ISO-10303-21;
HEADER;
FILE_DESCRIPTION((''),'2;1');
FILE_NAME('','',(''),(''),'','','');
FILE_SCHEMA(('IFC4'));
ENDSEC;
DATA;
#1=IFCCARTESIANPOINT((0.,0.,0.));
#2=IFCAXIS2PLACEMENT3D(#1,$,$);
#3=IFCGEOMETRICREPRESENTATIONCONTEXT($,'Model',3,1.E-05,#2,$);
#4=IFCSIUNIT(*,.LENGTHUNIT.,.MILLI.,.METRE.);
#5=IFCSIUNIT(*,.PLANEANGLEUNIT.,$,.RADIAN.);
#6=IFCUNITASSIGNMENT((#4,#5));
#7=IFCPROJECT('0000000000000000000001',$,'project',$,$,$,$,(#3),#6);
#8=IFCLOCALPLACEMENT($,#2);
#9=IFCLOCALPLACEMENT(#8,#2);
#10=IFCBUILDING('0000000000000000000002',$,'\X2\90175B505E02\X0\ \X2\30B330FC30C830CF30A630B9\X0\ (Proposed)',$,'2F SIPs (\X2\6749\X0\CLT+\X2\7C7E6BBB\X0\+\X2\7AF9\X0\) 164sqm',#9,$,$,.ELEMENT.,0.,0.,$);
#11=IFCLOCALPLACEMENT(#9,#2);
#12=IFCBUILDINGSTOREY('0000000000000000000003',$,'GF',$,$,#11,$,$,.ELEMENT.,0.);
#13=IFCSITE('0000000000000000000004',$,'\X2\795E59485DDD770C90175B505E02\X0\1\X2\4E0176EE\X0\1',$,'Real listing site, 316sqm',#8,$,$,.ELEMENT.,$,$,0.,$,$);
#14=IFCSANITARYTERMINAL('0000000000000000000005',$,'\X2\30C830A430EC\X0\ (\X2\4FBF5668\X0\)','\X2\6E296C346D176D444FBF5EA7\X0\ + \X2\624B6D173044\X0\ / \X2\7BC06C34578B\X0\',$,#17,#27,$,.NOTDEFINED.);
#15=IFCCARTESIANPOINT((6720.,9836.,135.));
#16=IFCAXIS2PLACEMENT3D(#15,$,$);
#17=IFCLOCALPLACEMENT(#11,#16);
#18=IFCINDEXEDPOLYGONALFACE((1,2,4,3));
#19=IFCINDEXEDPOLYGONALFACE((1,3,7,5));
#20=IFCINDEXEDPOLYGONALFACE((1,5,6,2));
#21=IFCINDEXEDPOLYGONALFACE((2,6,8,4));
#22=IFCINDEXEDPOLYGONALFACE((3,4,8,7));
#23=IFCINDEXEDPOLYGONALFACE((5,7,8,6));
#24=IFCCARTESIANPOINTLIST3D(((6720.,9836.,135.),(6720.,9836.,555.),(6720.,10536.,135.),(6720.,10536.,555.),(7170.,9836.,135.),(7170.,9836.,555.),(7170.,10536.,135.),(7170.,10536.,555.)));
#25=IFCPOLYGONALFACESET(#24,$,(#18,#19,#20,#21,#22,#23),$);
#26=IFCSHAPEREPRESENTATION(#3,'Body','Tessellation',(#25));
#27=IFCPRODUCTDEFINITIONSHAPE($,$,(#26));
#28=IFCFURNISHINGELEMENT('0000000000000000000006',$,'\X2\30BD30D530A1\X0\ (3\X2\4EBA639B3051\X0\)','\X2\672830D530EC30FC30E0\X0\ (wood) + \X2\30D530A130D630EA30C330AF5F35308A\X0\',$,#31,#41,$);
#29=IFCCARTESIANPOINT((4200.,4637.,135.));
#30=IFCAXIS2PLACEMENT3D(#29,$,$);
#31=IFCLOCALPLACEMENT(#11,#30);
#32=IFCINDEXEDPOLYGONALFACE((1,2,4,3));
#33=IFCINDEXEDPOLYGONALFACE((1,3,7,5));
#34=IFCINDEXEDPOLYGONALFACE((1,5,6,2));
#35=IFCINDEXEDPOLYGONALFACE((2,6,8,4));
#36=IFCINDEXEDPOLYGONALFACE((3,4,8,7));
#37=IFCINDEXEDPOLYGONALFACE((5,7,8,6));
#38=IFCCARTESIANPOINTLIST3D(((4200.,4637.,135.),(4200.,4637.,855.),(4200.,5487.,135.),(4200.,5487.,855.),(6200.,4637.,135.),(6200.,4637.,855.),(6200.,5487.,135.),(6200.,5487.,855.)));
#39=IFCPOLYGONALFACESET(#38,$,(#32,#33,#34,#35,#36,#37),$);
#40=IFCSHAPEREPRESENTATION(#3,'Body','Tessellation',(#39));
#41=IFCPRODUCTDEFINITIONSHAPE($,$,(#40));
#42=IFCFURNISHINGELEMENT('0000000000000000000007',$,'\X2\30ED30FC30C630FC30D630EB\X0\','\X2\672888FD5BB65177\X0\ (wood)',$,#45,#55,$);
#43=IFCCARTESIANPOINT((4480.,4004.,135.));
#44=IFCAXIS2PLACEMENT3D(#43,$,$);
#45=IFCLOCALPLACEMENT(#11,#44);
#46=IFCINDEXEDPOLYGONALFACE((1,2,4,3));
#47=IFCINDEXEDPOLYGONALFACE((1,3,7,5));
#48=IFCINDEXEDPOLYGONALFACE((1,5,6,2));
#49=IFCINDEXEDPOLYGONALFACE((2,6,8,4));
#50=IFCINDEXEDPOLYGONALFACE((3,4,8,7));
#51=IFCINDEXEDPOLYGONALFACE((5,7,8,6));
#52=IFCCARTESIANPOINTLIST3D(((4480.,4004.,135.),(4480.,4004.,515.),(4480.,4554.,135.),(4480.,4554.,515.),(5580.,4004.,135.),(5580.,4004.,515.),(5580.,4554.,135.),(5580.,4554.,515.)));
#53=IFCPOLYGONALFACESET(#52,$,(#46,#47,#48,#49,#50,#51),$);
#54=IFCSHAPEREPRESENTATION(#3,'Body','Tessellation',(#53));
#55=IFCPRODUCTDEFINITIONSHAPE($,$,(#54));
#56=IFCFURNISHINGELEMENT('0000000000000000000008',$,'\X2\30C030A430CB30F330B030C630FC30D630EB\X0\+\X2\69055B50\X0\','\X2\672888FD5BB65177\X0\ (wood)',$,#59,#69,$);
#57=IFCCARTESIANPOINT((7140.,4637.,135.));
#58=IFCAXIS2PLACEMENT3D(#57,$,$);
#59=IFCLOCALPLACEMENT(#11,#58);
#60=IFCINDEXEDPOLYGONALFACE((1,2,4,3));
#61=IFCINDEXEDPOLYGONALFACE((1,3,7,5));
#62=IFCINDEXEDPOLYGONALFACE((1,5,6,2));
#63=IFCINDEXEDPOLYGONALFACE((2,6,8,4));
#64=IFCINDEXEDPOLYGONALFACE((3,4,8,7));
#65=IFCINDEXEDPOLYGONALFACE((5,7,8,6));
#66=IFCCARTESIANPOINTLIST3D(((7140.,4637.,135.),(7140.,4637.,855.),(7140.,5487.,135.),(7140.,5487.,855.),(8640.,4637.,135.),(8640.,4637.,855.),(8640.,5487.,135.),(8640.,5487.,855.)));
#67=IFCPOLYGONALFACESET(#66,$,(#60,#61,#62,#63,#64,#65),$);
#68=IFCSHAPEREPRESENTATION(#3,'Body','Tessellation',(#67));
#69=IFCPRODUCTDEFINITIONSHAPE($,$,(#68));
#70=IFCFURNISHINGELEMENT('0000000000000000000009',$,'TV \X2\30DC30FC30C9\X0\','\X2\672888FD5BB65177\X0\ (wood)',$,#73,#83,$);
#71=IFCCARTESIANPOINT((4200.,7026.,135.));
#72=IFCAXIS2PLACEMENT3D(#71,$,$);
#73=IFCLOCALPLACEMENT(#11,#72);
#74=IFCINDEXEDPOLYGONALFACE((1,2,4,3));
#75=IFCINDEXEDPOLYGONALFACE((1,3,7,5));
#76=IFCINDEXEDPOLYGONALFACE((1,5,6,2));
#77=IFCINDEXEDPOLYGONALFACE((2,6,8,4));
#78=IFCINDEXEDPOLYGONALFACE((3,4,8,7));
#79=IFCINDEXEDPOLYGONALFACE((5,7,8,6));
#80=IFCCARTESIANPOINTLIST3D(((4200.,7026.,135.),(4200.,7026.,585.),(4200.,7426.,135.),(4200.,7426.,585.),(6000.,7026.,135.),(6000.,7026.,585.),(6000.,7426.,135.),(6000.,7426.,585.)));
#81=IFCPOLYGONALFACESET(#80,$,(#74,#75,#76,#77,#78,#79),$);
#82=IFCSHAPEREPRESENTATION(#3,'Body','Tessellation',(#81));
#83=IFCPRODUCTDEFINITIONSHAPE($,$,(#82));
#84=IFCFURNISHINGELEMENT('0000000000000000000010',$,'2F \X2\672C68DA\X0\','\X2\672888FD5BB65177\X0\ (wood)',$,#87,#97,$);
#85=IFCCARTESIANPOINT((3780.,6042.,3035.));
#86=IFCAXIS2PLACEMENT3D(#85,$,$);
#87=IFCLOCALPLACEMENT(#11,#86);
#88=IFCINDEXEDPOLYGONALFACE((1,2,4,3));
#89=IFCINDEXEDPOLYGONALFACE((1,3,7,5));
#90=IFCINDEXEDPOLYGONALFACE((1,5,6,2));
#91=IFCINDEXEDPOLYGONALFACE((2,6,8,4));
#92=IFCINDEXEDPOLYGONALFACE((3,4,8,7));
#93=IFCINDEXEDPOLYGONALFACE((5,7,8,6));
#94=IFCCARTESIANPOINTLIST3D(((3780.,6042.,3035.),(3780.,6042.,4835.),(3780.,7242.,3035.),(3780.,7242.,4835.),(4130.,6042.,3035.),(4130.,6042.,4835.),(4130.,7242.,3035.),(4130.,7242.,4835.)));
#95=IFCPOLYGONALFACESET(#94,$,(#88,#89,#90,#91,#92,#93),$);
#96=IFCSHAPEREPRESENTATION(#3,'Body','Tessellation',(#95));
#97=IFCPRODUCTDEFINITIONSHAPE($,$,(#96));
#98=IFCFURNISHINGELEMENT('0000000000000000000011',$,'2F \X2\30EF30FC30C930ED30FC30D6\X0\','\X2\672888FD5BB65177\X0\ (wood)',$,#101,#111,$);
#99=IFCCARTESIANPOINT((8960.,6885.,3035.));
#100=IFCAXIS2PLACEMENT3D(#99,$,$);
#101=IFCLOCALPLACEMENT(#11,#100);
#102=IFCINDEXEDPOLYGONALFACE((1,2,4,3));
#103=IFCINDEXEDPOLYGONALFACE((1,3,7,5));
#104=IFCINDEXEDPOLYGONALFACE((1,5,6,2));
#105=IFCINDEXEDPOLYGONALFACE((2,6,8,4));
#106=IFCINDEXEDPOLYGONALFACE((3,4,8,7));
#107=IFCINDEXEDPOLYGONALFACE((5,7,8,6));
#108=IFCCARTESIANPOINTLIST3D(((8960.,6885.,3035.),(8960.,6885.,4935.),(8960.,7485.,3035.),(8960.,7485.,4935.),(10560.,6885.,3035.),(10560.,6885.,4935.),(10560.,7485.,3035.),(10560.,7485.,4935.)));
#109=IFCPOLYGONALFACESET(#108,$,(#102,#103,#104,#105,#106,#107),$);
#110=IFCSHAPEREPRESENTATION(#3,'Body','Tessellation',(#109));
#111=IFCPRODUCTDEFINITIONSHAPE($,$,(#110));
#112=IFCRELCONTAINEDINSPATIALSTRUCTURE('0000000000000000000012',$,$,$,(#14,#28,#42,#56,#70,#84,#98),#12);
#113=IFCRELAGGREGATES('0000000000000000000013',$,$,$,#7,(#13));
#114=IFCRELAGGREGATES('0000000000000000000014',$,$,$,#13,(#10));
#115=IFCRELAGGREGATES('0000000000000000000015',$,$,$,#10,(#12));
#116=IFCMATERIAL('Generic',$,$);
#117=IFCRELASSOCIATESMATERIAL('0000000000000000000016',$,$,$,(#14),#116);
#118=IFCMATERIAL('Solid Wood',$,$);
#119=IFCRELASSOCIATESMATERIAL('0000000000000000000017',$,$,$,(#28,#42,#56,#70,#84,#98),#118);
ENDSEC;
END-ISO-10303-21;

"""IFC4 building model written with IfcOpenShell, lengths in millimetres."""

from ifc_helpers import new_model, si_unit, frame, frame_2d, origin, place, context, project, spatial, rectangle, extrude, material, element, save


model = new_model("IFC4")

# Units and contexts
model_context = context("Model", 3, precision=1e-05, world=origin())
ifc_project = project(units=[si_unit("LENGTHUNIT", "METRE", prefix="MILLI"), si_unit("PLANEANGLEUNIT", "RADIAN")], contexts=[model_context])

# Site, building, storey
site_placement = place(None, origin())
site = spatial("IfcSite", under=ifc_project, at=site_placement, Name="神奈川県逗子市1丁目1", ObjectType="Real listing site, 316sqm", CompositionType="ELEMENT", RefElevation=0.0)
building_placement = place(site_placement, origin())
building = spatial("IfcBuilding", under=site, at=building_placement, Name="逗子市 コートハウス (Proposed)", ObjectType="2F SIPs (杉CLT+籾殻+竹) 164sqm", CompositionType="ELEMENT", ElevationOfRefHeight=0.0, ElevationOfTerrain=0.0)
storey_placement = place(building_placement, origin())
storey = spatial("IfcBuildingStorey", under=building, at=storey_placement, Name="GF", CompositionType="ELEMENT", Elevation=0.0)

# Shared definitions
ifc_material_1 = material(Name="Generic")

# Shared definitions
ifc_material_2 = material(Name="Solid Wood")

# Sanitary terminal
sanitary_terminal_1_placement = place(storey_placement, frame((6720.0, 9836.0, 135.0)))
element("IfcSanitaryTerminal", 1, at=sanitary_terminal_1_placement, inside=storey, material=ifc_material_1, Name="トイレ (便器)", Description="温水洗浄便座 + 手洗い / 節水型", PredefinedType="NOTDEFINED", context=model_context, shape_type="SweptSolid", body=[
    extrude(rectangle(XDim=450.0, YDim=700.0, at=frame_2d((225.0, 350.0))), frame((6720.0, 9836.0, 135.0)), (0.0, 0.0, 1.0), 420.0),
])

# Furnishing elements
furnishing_1_placement = place(storey_placement, frame((4200.0, 4637.0, 135.0)))
element("IfcFurnishingElement", 2, at=furnishing_1_placement, inside=storey, material=ifc_material_2, Name="ソファ (3人掛け)", Description="木フレーム (wood) + ファブリック張り", context=model_context, shape_type="SweptSolid", body=[
    extrude(rectangle(XDim=2000.0, YDim=850.0, at=frame_2d((1000.0, 425.0))), frame((4200.0, 4637.0, 135.0)), (0.0, 0.0, 1.0), 720.0),
])
furnishing_2_placement = place(storey_placement, frame((4480.0, 4004.0, 135.0)))
element("IfcFurnishingElement", 3, at=furnishing_2_placement, inside=storey, material=ifc_material_2, Name="ローテーブル", Description="木製家具 (wood)", context=model_context, shape_type="SweptSolid", body=[
    extrude(rectangle(XDim=1100.0, YDim=550.0, at=frame_2d((550.0, 275.0))), frame((4480.0, 4004.0, 135.0)), (0.0, 0.0, 1.0), 380.0),
])
furnishing_3_placement = place(storey_placement, frame((7140.0, 4637.0, 135.0)))
element("IfcFurnishingElement", 4, at=furnishing_3_placement, inside=storey, material=ifc_material_2, Name="ダイニングテーブル+椅子", Description="木製家具 (wood)", context=model_context, shape_type="SweptSolid", body=[
    extrude(rectangle(XDim=1500.0, YDim=850.0, at=frame_2d((750.0, 425.0))), frame((7140.0, 4637.0, 135.0)), (0.0, 0.0, 1.0), 720.0),
])
furnishing_4_placement = place(storey_placement, frame((4200.0, 7026.0, 135.0)))
element("IfcFurnishingElement", 5, at=furnishing_4_placement, inside=storey, material=ifc_material_2, Name="TV ボード", Description="木製家具 (wood)", context=model_context, shape_type="SweptSolid", body=[
    extrude(rectangle(XDim=1800.0, YDim=400.0, at=frame_2d((900.0, 200.0))), frame((4200.0, 7026.0, 135.0)), (0.0, 0.0, 1.0), 450.0),
])
furnishing_5_placement = place(storey_placement, frame((3780.0, 6042.0, 3035.0)))
element("IfcFurnishingElement", 6, at=furnishing_5_placement, inside=storey, material=ifc_material_2, Name="2F 本棚", Description="木製家具 (wood)", context=model_context, shape_type="SweptSolid", body=[
    extrude(rectangle(XDim=350.0, YDim=1200.0, at=frame_2d((175.0, 600.0))), frame((3780.0, 6042.0, 3035.0)), (0.0, 0.0, 1.0), 1800.0),
])
furnishing_6_placement = place(storey_placement, frame((8960.0, 6885.0, 3035.0)))
element("IfcFurnishingElement", 7, at=furnishing_6_placement, inside=storey, material=ifc_material_2, Name="2F ワードローブ", Description="木製家具 (wood)", context=model_context, shape_type="SweptSolid", body=[
    extrude(rectangle(XDim=1600.0, YDim=600.0, at=frame_2d((800.0, 300.0))), frame((8960.0, 6885.0, 3035.0)), (0.0, 0.0, 1.0), 1900.0),
])

save(model, "model.ifc")
